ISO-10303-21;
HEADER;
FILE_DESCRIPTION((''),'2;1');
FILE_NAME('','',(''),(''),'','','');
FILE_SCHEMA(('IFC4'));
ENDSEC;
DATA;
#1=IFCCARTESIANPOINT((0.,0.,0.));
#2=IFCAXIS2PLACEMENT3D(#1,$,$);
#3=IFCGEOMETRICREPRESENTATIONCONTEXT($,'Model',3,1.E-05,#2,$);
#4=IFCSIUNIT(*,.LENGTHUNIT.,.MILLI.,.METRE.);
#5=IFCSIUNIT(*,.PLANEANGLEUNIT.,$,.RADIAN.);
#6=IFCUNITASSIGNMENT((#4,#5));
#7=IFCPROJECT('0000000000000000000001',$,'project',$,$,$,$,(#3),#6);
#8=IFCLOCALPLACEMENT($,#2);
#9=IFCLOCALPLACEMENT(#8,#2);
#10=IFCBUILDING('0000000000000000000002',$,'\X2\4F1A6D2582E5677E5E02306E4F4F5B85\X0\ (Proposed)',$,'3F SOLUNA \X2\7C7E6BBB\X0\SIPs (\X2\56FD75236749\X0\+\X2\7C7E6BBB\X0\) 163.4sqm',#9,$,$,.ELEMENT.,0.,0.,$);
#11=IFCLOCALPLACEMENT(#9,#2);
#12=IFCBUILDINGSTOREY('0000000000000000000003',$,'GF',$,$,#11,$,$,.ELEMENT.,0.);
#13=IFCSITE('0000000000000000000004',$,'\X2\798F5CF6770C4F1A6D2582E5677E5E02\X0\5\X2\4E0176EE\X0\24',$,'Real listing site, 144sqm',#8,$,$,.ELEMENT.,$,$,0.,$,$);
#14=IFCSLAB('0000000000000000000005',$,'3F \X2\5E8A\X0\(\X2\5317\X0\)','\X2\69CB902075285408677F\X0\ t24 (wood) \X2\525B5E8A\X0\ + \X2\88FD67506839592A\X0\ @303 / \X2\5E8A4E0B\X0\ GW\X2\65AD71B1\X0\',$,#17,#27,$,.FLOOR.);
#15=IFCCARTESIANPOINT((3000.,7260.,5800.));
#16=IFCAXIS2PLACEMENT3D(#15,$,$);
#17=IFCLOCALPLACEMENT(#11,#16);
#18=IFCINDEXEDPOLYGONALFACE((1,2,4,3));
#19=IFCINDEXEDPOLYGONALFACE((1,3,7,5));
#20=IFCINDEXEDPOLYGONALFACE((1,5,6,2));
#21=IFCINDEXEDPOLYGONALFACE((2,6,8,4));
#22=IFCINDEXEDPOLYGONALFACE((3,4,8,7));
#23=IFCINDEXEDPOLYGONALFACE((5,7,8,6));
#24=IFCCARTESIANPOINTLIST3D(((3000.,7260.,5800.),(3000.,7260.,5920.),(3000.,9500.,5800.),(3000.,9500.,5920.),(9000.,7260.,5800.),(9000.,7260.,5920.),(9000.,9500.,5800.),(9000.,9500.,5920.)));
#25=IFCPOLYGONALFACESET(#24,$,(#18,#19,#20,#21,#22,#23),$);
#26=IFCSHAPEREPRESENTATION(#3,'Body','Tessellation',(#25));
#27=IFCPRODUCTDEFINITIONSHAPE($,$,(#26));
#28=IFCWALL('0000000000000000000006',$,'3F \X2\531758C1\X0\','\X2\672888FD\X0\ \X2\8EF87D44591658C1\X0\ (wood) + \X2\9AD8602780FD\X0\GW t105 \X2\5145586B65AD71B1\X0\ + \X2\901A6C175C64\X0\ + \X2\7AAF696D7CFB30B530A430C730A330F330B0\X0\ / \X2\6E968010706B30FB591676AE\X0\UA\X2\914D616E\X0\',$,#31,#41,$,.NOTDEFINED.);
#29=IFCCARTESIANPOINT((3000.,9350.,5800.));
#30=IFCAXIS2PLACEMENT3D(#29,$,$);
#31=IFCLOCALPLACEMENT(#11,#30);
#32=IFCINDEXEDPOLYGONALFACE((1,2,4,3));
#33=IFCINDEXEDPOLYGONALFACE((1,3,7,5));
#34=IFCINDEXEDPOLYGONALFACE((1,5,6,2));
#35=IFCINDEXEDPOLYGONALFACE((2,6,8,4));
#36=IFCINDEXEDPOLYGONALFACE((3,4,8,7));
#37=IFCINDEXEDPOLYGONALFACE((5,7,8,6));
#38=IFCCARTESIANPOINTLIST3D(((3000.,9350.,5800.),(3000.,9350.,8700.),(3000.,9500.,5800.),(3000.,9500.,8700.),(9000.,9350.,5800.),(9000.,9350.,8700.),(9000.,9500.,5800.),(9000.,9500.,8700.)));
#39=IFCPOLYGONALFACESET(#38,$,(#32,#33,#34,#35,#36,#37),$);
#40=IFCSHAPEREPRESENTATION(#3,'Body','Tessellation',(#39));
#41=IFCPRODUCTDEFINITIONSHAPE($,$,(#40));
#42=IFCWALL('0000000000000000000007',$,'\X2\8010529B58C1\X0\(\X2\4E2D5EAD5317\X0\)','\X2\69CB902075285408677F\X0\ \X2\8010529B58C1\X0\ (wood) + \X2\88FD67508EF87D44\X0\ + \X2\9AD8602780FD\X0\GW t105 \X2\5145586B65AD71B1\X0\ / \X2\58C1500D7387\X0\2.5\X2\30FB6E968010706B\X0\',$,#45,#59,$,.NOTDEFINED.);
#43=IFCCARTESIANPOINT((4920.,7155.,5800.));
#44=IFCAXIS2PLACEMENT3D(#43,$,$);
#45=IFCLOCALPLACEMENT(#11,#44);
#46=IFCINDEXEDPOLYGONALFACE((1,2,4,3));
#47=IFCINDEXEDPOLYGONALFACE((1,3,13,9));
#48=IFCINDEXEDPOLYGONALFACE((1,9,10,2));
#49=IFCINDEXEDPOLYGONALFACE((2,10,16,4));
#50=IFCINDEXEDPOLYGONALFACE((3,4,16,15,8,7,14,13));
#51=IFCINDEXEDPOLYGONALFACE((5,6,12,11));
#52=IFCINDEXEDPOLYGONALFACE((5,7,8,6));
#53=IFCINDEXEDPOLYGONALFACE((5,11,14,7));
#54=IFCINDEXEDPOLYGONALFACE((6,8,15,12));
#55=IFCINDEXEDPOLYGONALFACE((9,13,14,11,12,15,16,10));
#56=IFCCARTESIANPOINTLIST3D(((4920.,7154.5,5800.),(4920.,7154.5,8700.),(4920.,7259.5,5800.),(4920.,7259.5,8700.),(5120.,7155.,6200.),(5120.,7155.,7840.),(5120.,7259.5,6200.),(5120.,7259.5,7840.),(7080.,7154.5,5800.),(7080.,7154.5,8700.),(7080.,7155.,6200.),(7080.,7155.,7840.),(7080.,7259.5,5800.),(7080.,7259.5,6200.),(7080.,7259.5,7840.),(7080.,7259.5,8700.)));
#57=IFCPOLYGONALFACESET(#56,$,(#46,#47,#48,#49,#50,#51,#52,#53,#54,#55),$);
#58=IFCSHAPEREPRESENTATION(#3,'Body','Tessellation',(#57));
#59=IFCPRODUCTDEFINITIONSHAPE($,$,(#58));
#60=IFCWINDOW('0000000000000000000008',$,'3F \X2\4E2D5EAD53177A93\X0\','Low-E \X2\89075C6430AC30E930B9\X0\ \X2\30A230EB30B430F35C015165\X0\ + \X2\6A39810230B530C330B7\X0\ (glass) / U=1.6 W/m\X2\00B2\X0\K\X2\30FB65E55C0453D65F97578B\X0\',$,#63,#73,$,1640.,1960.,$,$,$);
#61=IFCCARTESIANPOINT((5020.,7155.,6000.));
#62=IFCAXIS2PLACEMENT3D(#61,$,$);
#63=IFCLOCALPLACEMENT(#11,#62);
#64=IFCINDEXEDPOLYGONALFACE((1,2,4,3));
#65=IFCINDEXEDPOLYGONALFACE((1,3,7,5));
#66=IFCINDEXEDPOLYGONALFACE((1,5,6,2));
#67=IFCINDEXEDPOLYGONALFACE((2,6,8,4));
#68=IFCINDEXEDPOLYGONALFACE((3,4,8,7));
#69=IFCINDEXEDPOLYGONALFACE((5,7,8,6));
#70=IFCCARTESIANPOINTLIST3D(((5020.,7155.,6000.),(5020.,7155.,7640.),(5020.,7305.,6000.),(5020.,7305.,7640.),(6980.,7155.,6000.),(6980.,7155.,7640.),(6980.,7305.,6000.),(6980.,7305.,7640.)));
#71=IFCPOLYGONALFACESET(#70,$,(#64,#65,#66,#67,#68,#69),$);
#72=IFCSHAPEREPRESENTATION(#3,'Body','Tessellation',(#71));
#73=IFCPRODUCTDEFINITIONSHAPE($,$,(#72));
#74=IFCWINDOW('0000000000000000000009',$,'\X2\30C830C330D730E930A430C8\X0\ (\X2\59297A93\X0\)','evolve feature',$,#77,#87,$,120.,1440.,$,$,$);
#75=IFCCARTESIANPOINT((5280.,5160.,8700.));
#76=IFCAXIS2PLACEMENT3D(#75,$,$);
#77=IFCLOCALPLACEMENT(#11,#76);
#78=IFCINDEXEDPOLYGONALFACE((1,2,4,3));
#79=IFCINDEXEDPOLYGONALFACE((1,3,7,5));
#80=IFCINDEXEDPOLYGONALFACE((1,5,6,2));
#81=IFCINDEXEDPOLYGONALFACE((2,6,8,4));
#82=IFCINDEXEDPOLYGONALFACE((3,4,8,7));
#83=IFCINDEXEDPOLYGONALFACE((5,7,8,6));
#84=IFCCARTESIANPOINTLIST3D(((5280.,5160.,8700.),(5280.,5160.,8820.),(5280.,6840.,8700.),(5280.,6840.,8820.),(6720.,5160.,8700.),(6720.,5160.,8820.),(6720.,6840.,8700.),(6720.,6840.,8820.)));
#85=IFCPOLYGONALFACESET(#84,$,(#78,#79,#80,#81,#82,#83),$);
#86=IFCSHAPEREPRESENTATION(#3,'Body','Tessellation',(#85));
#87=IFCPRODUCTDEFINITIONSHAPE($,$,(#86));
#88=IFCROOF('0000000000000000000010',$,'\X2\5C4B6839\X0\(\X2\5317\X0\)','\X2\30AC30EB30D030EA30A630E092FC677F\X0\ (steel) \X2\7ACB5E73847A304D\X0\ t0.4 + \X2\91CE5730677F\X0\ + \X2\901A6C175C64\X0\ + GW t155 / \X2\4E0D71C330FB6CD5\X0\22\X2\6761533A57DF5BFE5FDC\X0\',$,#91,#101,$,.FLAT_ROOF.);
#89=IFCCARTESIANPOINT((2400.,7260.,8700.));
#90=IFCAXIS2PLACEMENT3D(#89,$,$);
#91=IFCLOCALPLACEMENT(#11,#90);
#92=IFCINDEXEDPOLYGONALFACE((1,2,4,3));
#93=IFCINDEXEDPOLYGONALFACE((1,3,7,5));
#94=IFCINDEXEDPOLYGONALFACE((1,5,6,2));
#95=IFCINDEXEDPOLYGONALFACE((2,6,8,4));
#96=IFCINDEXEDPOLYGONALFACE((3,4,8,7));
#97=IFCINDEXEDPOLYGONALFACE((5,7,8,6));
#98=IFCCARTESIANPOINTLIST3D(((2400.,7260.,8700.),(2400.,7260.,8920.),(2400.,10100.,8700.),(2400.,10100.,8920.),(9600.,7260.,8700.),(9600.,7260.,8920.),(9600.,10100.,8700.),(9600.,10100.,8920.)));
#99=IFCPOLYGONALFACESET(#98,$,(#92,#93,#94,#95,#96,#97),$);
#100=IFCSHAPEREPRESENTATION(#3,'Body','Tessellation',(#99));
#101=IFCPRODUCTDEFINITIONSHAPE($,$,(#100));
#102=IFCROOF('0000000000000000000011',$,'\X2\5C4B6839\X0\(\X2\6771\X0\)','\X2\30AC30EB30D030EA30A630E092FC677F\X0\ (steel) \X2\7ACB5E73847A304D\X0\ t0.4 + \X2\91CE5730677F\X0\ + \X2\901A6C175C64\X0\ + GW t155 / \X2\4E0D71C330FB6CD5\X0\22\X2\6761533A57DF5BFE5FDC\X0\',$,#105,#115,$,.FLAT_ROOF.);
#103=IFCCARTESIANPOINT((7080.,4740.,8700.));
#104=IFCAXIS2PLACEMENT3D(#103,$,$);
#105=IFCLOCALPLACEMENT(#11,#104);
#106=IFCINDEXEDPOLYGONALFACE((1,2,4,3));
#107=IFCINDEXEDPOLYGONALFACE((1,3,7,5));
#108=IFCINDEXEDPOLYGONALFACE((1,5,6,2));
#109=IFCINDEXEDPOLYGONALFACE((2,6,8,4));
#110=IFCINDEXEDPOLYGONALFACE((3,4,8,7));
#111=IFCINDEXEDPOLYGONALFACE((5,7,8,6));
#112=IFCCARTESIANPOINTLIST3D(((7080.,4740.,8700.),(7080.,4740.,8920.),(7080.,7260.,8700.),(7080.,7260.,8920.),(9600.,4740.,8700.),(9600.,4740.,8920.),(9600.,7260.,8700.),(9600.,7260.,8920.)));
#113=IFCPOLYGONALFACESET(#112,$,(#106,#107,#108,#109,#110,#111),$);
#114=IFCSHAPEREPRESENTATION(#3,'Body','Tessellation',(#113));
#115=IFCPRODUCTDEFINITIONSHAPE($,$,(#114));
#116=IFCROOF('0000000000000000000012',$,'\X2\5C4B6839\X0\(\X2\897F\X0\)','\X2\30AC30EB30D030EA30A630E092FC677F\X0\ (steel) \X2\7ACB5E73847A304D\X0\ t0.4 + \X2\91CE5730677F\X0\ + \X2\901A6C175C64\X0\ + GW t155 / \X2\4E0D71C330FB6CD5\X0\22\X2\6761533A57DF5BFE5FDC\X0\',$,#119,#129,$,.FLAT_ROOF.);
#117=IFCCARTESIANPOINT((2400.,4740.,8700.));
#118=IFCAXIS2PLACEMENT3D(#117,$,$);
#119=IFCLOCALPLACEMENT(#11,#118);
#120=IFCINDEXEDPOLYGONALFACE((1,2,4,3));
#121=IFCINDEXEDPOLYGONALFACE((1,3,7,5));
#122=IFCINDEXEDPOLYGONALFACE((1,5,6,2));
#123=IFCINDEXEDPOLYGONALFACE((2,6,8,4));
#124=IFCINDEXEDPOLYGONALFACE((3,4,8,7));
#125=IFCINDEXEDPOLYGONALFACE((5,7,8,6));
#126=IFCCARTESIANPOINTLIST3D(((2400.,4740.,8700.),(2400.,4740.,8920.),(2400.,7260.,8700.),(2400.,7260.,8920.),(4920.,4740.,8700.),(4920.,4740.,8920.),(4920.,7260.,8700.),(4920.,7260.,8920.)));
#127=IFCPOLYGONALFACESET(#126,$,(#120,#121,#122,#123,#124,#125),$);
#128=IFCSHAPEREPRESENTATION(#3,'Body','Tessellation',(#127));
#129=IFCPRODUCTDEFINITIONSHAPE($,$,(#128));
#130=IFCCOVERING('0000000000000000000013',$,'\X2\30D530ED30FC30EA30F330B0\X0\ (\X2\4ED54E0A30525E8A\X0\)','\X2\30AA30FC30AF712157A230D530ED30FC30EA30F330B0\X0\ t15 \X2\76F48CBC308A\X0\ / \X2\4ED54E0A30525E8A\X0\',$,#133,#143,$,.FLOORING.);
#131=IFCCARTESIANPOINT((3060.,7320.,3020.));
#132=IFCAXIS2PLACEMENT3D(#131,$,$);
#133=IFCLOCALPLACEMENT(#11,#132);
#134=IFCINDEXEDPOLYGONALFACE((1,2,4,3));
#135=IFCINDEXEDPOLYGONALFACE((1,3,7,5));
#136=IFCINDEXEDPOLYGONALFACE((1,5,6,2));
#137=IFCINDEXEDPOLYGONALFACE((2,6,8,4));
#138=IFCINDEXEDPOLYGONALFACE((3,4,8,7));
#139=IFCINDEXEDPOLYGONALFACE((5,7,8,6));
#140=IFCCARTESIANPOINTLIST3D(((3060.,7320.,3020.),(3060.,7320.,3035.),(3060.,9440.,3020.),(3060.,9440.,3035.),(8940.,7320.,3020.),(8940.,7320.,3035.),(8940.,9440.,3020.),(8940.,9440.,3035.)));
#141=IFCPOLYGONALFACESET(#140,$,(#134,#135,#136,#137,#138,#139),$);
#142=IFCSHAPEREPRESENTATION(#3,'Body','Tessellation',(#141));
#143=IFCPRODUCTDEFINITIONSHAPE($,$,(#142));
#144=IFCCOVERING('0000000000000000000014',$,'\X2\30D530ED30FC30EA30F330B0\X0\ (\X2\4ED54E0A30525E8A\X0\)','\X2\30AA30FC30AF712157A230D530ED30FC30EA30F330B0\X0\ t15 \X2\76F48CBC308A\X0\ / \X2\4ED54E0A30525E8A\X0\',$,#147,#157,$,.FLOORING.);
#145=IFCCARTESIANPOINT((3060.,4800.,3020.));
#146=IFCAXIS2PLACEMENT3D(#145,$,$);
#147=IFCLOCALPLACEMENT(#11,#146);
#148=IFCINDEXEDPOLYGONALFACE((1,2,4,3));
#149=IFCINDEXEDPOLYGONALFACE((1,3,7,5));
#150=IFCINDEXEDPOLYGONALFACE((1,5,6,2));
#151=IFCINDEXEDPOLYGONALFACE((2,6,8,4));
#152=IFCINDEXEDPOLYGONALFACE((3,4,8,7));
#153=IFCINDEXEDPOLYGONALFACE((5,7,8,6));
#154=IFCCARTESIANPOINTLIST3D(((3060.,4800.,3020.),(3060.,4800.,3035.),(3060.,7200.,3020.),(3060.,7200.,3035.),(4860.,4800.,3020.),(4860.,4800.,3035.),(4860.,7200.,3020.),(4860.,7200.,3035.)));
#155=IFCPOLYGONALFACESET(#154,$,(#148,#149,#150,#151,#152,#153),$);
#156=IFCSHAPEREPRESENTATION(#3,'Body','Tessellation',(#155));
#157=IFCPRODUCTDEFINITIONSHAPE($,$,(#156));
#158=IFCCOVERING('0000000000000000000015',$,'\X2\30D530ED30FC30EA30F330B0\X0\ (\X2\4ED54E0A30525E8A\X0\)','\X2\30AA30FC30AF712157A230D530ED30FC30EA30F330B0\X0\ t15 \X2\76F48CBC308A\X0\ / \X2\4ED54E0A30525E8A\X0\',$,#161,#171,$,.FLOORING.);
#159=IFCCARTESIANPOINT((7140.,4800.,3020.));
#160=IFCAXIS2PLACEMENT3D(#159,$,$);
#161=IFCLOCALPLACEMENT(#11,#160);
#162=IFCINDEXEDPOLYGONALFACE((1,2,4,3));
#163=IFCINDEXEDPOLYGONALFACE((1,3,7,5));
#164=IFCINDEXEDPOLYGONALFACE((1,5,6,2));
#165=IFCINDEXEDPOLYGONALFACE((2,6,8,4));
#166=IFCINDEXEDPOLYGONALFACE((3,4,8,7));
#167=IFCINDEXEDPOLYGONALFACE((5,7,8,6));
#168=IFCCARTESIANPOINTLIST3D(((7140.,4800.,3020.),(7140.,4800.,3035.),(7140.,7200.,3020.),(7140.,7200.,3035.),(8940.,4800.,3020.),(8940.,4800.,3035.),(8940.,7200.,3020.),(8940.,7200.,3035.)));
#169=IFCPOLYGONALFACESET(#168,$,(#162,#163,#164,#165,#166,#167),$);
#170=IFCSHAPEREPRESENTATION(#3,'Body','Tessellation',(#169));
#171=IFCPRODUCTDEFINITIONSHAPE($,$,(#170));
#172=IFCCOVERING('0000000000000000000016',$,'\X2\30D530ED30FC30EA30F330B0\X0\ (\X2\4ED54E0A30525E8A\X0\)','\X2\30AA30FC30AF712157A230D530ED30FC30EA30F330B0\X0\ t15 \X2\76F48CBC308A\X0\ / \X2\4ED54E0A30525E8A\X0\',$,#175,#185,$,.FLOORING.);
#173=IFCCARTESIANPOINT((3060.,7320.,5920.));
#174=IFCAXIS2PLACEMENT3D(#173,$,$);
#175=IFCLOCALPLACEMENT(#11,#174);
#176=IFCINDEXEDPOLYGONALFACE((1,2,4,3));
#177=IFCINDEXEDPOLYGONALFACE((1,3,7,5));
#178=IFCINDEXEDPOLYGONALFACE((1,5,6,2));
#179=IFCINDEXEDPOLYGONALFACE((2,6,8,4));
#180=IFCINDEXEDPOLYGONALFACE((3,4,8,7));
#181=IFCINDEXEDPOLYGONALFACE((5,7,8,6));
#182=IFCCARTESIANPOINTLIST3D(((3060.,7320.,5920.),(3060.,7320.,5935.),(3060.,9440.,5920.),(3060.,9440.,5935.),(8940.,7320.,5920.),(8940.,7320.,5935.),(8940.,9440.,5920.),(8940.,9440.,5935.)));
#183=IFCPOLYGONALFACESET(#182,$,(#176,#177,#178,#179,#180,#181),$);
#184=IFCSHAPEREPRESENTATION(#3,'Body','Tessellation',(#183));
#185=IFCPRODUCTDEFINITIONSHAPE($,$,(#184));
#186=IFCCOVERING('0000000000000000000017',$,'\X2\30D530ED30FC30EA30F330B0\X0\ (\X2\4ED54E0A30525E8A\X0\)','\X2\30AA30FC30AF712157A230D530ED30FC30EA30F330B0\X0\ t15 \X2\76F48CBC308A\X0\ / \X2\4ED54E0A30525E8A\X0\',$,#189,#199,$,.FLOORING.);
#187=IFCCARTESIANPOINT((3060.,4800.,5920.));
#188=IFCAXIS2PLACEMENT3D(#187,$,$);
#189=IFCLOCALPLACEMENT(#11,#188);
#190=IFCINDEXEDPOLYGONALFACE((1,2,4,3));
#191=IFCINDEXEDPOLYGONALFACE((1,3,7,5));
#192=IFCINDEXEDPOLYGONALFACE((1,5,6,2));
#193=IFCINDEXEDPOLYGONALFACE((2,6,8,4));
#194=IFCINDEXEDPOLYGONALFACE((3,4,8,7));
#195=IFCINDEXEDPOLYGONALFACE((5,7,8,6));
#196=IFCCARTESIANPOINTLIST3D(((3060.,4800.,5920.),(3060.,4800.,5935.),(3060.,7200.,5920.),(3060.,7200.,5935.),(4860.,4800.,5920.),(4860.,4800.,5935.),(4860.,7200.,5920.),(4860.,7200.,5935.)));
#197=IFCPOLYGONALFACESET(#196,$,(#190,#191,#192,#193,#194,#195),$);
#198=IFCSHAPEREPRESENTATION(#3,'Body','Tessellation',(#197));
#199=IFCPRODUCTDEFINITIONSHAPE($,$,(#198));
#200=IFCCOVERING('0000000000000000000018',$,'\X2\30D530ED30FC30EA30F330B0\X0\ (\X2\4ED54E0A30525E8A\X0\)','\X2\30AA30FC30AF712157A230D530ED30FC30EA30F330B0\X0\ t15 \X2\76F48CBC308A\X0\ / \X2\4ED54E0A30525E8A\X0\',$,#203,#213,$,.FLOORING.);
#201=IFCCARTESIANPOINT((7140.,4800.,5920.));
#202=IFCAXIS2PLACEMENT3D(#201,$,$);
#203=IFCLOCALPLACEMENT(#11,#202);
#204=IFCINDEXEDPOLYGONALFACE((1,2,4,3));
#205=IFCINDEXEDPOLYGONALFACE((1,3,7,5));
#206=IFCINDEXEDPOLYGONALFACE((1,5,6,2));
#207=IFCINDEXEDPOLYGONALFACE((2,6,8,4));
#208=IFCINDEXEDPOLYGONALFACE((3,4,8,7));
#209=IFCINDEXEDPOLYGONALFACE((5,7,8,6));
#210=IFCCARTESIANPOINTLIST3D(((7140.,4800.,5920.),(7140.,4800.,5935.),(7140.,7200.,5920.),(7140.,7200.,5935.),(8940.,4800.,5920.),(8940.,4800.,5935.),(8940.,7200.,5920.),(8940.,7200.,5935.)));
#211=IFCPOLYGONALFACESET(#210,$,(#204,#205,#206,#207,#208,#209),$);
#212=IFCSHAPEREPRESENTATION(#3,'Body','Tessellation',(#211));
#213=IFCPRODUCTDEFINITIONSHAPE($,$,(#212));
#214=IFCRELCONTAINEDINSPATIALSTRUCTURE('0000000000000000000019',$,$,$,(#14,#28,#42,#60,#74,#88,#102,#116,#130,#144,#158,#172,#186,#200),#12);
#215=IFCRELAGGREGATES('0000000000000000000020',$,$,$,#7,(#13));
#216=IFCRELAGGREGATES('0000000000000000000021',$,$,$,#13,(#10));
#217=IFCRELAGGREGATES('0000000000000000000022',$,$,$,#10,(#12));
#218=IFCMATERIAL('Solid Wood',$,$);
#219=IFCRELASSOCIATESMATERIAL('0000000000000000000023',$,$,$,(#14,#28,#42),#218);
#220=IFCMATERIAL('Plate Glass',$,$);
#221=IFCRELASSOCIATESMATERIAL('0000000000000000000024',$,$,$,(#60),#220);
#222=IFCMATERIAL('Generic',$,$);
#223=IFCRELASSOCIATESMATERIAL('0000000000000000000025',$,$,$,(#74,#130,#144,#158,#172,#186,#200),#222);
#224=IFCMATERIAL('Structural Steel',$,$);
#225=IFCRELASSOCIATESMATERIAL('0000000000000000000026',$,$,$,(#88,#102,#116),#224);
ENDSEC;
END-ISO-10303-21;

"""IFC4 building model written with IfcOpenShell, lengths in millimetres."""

from ifc_helpers import new_model, si_unit, frame, frame_2d, origin, place, context, project, spatial, rectangle, extrude, material, element, fill, save


model = new_model("IFC4")

# Units and contexts
model_context = context("Model", 3, precision=1e-05, world=origin())
ifc_project = project(units=[si_unit("LENGTHUNIT", "METRE", prefix="MILLI"), si_unit("PLANEANGLEUNIT", "RADIAN")], contexts=[model_context])

# Site, building, storey
site_placement = place(None, origin())
site = spatial("IfcSite", under=ifc_project, at=site_placement, Name="福島県会津若松市5丁目24", ObjectType="Real listing site, 144sqm", CompositionType="ELEMENT", RefElevation=0.0)
building_placement = place(site_placement, origin())
building = spatial("IfcBuilding", under=site, at=building_placement, Name="会津若松市の住宅 (Proposed)", ObjectType="3F SOLUNA 籾殻SIPs (国産杉+籾殻) 163.4sqm", CompositionType="ELEMENT", ElevationOfRefHeight=0.0, ElevationOfTerrain=0.0)
storey_placement = place(building_placement, origin())
storey = spatial("IfcBuildingStorey", under=building, at=storey_placement, Name="GF", CompositionType="ELEMENT", Elevation=0.0)

# Slab
ifc_material_1 = material(Name="Solid Wood")
slab_placement = place(storey_placement, frame((3000.0, 7260.0, 5800.0)))
element("IfcSlab", 1, at=slab_placement, inside=storey, material=ifc_material_1, Name="3F 床(北)", Description="構造用合板 t24 (wood) 剛床 + 製材根太 @303 / 床下 GW断熱", PredefinedType="FLOOR", context=model_context, shape_type="SweptSolid", body=[
    extrude(rectangle(XDim=6000.0, YDim=2240.0, at=frame_2d((3000.0, 1120.0))), frame((3000.0, 7260.0, 5800.0)), (0.0, 0.0, 1.0), 120.0),
])

# Wall
wall_1_placement = place(storey_placement, frame((3000.0, 9350.0, 5800.0)))
element("IfcWall", 2, at=wall_1_placement, inside=storey, material=ifc_material_1, Name="3F 北壁", Description="木製 軸組外壁 (wood) + 高性能GW t105 充填断熱 + 通気層 + 窯業系サイディング / 準耐火・外皮UA配慮", PredefinedType="NOTDEFINED", context=model_context, shape_type="SweptSolid", body=[
    extrude(rectangle(XDim=6000.0, YDim=150.0, at=frame_2d((3000.0, 75.0))), frame((3000.0, 9350.0, 5800.0)), (0.0, 0.0, 1.0), 2900.0),
])

# Wall, opening, window
wall_2_placement = place(storey_placement, frame((4920.0, 7155.0, 5800.0)))
wall_2 = element("IfcWall", 3, at=wall_2_placement, inside=storey, material=ifc_material_1, Name="耐力壁(中庭北)", Description="構造用合板 耐力壁 (wood) + 製材軸組 + 高性能GW t105 充填断熱 / 壁倍率2.5・準耐火", PredefinedType="NOTDEFINED", context=model_context, shape_type="SweptSolid", body=[
    extrude(rectangle(XDim=2160.0, YDim=105.0, at=frame_2d((1080.0, 52.0))), frame((4920.0, 7155.0, 5800.0)), (0.0, 0.0, 1.0), 2900.0),
])
opening_placement = place(storey_placement, frame((5020.0, 7155.0, 6000.0)))
opening = element("IfcOpeningElement", 4, at=opening_placement, cuts=wall_2, PredefinedType="NOTDEFINED", context=model_context, shape_type="SweptSolid", body=[
    extrude(rectangle(XDim=1960.0, YDim=150.0, at=frame_2d((980.0, 75.0))), frame((5020.0, 7155.0, 6000.0)), (0.0, 0.0, 1.0), 1640.0),
])
ifc_material_2 = material(Name="Plate Glass")
window_1_placement = place(storey_placement, frame((5020.0, 7155.0, 6000.0)))
window_1 = element("IfcWindow", 5, at=window_1_placement, inside=storey, material=ifc_material_2, Name="3F 中庭北窓", Description="Low-E 複層ガラス アルゴン封入 + 樹脂サッシ (glass) / U=1.6 W/m²K・日射取得型", OverallHeight=1640.0, OverallWidth=1960.0, context=model_context, shape_type="SweptSolid", body=[
    extrude(rectangle(XDim=1960.0, YDim=150.0, at=frame_2d((980.0, 75.0))), frame((5020.0, 7155.0, 6000.0)), (0.0, 0.0, 1.0), 1640.0),
])
fill(opening, window_1)

# Window
ifc_material_3 = material(Name="Generic")
window_2_placement = place(storey_placement, frame((5280.0, 5160.0, 8700.0)))
element("IfcWindow", 6, at=window_2_placement, inside=storey, material=ifc_material_3, Name="トップライト (天窓)", Description="evolve feature", OverallHeight=120.0, OverallWidth=1440.0, context=model_context, shape_type="SweptSolid", body=[
    extrude(rectangle(XDim=1440.0, YDim=1680.0, at=frame_2d((720.0, 840.0))), frame((5280.0, 5160.0, 8700.0)), (0.0, 0.0, 1.0), 120.0),
])

# Roofs
ifc_material_4 = material(Name="Structural Steel")
roof_1_placement = place(storey_placement, frame((2400.0, 7260.0, 8700.0)))
element("IfcRoof", 7, at=roof_1_placement, inside=storey, material=ifc_material_4, Name="屋根(北)", Description="ガルバリウム鋼板 (steel) 立平葺き t0.4 + 野地板 + 通気層 + GW t155 / 不燃・法22条区域対応", PredefinedType="FLAT_ROOF", context=model_context, shape_type="SweptSolid", body=[
    extrude(rectangle(XDim=7200.0, YDim=2840.0, at=frame_2d((3600.0, 1420.0))), frame((2400.0, 7260.0, 8700.0)), (0.0, 0.0, 1.0), 220.0),
])
roof_2_placement = place(storey_placement, frame((7080.0, 4740.0, 8700.0)))
element("IfcRoof", 8, at=roof_2_placement, inside=storey, material=ifc_material_4, Name="屋根(東)", Description="ガルバリウム鋼板 (steel) 立平葺き t0.4 + 野地板 + 通気層 + GW t155 / 不燃・法22条区域対応", PredefinedType="FLAT_ROOF", context=model_context, shape_type="SweptSolid", body=[
    extrude(rectangle(XDim=2520.0, YDim=2520.0, at=frame_2d((1260.0, 1260.0))), frame((7080.0, 4740.0, 8700.0)), (0.0, 0.0, 1.0), 220.0),
])
roof_3_placement = place(storey_placement, frame((2400.0, 4740.0, 8700.0)))
element("IfcRoof", 9, at=roof_3_placement, inside=storey, material=ifc_material_4, Name="屋根(西)", Description="ガルバリウム鋼板 (steel) 立平葺き t0.4 + 野地板 + 通気層 + GW t155 / 不燃・法22条区域対応", PredefinedType="FLAT_ROOF", context=model_context, shape_type="SweptSolid", body=[
    extrude(rectangle(XDim=2520.0, YDim=2520.0, at=frame_2d((1260.0, 1260.0))), frame((2400.0, 4740.0, 8700.0)), (0.0, 0.0, 1.0), 220.0),
])

# Coverings
covering_1_placement = place(storey_placement, frame((3060.0, 7320.0, 3020.0)))
element("IfcCovering", 10, at=covering_1_placement, inside=storey, material=ifc_material_3, Name="フローリング (仕上げ床)", Description="オーク無垢フローリング t15 直貼り / 仕上げ床", PredefinedType="FLOORING", context=model_context, shape_type="SweptSolid", body=[
    extrude(rectangle(XDim=5880.0, YDim=2120.0, at=frame_2d((2940.0, 1060.0))), frame((3060.0, 7320.0, 3020.0)), (0.0, 0.0, 1.0), 15.0),
])
covering_2_placement = place(storey_placement, frame((3060.0, 4800.0, 3020.0)))
element("IfcCovering", 11, at=covering_2_placement, inside=storey, material=ifc_material_3, Name="フローリング (仕上げ床)", Description="オーク無垢フローリング t15 直貼り / 仕上げ床", PredefinedType="FLOORING", context=model_context, shape_type="SweptSolid", body=[
    extrude(rectangle(XDim=1800.0, YDim=2400.0, at=frame_2d((900.0, 1200.0))), frame((3060.0, 4800.0, 3020.0)), (0.0, 0.0, 1.0), 15.0),
])
covering_3_placement = place(storey_placement, frame((7140.0, 4800.0, 3020.0)))
element("IfcCovering", 12, at=covering_3_placement, inside=storey, material=ifc_material_3, Name="フローリング (仕上げ床)", Description="オーク無垢フローリング t15 直貼り / 仕上げ床", PredefinedType="FLOORING", context=model_context, shape_type="SweptSolid", body=[
    extrude(rectangle(XDim=1800.0, YDim=2400.0, at=frame_2d((900.0, 1200.0))), frame((7140.0, 4800.0, 3020.0)), (0.0, 0.0, 1.0), 15.0),
])
covering_4_placement = place(storey_placement, frame((3060.0, 7320.0, 5920.0)))
element("IfcCovering", 13, at=covering_4_placement, inside=storey, material=ifc_material_3, Name="フローリング (仕上げ床)", Description="オーク無垢フローリング t15 直貼り / 仕上げ床", PredefinedType="FLOORING", context=model_context, shape_type="SweptSolid", body=[
    extrude(rectangle(XDim=5880.0, YDim=2120.0, at=frame_2d((2940.0, 1060.0))), frame((3060.0, 7320.0, 5920.0)), (0.0, 0.0, 1.0), 15.0),
])
covering_5_placement = place(storey_placement, frame((3060.0, 4800.0, 5920.0)))
element("IfcCovering", 14, at=covering_5_placement, inside=storey, material=ifc_material_3, Name="フローリング (仕上げ床)", Description="オーク無垢フローリング t15 直貼り / 仕上げ床", PredefinedType="FLOORING", context=model_context, shape_type="SweptSolid", body=[
    extrude(rectangle(XDim=1800.0, YDim=2400.0, at=frame_2d((900.0, 1200.0))), frame((3060.0, 4800.0, 5920.0)), (0.0, 0.0, 1.0), 15.0),
])
covering_6_placement = place(storey_placement, frame((7140.0, 4800.0, 5920.0)))
element("IfcCovering", 15, at=covering_6_placement, inside=storey, material=ifc_material_3, Name="フローリング (仕上げ床)", Description="オーク無垢フローリング t15 直貼り / 仕上げ床", PredefinedType="FLOORING", context=model_context, shape_type="SweptSolid", body=[
    extrude(rectangle(XDim=1800.0, YDim=2400.0, at=frame_2d((900.0, 1200.0))), frame((7140.0, 4800.0, 5920.0)), (0.0, 0.0, 1.0), 15.0),
])

save(model, "model.ifc")
